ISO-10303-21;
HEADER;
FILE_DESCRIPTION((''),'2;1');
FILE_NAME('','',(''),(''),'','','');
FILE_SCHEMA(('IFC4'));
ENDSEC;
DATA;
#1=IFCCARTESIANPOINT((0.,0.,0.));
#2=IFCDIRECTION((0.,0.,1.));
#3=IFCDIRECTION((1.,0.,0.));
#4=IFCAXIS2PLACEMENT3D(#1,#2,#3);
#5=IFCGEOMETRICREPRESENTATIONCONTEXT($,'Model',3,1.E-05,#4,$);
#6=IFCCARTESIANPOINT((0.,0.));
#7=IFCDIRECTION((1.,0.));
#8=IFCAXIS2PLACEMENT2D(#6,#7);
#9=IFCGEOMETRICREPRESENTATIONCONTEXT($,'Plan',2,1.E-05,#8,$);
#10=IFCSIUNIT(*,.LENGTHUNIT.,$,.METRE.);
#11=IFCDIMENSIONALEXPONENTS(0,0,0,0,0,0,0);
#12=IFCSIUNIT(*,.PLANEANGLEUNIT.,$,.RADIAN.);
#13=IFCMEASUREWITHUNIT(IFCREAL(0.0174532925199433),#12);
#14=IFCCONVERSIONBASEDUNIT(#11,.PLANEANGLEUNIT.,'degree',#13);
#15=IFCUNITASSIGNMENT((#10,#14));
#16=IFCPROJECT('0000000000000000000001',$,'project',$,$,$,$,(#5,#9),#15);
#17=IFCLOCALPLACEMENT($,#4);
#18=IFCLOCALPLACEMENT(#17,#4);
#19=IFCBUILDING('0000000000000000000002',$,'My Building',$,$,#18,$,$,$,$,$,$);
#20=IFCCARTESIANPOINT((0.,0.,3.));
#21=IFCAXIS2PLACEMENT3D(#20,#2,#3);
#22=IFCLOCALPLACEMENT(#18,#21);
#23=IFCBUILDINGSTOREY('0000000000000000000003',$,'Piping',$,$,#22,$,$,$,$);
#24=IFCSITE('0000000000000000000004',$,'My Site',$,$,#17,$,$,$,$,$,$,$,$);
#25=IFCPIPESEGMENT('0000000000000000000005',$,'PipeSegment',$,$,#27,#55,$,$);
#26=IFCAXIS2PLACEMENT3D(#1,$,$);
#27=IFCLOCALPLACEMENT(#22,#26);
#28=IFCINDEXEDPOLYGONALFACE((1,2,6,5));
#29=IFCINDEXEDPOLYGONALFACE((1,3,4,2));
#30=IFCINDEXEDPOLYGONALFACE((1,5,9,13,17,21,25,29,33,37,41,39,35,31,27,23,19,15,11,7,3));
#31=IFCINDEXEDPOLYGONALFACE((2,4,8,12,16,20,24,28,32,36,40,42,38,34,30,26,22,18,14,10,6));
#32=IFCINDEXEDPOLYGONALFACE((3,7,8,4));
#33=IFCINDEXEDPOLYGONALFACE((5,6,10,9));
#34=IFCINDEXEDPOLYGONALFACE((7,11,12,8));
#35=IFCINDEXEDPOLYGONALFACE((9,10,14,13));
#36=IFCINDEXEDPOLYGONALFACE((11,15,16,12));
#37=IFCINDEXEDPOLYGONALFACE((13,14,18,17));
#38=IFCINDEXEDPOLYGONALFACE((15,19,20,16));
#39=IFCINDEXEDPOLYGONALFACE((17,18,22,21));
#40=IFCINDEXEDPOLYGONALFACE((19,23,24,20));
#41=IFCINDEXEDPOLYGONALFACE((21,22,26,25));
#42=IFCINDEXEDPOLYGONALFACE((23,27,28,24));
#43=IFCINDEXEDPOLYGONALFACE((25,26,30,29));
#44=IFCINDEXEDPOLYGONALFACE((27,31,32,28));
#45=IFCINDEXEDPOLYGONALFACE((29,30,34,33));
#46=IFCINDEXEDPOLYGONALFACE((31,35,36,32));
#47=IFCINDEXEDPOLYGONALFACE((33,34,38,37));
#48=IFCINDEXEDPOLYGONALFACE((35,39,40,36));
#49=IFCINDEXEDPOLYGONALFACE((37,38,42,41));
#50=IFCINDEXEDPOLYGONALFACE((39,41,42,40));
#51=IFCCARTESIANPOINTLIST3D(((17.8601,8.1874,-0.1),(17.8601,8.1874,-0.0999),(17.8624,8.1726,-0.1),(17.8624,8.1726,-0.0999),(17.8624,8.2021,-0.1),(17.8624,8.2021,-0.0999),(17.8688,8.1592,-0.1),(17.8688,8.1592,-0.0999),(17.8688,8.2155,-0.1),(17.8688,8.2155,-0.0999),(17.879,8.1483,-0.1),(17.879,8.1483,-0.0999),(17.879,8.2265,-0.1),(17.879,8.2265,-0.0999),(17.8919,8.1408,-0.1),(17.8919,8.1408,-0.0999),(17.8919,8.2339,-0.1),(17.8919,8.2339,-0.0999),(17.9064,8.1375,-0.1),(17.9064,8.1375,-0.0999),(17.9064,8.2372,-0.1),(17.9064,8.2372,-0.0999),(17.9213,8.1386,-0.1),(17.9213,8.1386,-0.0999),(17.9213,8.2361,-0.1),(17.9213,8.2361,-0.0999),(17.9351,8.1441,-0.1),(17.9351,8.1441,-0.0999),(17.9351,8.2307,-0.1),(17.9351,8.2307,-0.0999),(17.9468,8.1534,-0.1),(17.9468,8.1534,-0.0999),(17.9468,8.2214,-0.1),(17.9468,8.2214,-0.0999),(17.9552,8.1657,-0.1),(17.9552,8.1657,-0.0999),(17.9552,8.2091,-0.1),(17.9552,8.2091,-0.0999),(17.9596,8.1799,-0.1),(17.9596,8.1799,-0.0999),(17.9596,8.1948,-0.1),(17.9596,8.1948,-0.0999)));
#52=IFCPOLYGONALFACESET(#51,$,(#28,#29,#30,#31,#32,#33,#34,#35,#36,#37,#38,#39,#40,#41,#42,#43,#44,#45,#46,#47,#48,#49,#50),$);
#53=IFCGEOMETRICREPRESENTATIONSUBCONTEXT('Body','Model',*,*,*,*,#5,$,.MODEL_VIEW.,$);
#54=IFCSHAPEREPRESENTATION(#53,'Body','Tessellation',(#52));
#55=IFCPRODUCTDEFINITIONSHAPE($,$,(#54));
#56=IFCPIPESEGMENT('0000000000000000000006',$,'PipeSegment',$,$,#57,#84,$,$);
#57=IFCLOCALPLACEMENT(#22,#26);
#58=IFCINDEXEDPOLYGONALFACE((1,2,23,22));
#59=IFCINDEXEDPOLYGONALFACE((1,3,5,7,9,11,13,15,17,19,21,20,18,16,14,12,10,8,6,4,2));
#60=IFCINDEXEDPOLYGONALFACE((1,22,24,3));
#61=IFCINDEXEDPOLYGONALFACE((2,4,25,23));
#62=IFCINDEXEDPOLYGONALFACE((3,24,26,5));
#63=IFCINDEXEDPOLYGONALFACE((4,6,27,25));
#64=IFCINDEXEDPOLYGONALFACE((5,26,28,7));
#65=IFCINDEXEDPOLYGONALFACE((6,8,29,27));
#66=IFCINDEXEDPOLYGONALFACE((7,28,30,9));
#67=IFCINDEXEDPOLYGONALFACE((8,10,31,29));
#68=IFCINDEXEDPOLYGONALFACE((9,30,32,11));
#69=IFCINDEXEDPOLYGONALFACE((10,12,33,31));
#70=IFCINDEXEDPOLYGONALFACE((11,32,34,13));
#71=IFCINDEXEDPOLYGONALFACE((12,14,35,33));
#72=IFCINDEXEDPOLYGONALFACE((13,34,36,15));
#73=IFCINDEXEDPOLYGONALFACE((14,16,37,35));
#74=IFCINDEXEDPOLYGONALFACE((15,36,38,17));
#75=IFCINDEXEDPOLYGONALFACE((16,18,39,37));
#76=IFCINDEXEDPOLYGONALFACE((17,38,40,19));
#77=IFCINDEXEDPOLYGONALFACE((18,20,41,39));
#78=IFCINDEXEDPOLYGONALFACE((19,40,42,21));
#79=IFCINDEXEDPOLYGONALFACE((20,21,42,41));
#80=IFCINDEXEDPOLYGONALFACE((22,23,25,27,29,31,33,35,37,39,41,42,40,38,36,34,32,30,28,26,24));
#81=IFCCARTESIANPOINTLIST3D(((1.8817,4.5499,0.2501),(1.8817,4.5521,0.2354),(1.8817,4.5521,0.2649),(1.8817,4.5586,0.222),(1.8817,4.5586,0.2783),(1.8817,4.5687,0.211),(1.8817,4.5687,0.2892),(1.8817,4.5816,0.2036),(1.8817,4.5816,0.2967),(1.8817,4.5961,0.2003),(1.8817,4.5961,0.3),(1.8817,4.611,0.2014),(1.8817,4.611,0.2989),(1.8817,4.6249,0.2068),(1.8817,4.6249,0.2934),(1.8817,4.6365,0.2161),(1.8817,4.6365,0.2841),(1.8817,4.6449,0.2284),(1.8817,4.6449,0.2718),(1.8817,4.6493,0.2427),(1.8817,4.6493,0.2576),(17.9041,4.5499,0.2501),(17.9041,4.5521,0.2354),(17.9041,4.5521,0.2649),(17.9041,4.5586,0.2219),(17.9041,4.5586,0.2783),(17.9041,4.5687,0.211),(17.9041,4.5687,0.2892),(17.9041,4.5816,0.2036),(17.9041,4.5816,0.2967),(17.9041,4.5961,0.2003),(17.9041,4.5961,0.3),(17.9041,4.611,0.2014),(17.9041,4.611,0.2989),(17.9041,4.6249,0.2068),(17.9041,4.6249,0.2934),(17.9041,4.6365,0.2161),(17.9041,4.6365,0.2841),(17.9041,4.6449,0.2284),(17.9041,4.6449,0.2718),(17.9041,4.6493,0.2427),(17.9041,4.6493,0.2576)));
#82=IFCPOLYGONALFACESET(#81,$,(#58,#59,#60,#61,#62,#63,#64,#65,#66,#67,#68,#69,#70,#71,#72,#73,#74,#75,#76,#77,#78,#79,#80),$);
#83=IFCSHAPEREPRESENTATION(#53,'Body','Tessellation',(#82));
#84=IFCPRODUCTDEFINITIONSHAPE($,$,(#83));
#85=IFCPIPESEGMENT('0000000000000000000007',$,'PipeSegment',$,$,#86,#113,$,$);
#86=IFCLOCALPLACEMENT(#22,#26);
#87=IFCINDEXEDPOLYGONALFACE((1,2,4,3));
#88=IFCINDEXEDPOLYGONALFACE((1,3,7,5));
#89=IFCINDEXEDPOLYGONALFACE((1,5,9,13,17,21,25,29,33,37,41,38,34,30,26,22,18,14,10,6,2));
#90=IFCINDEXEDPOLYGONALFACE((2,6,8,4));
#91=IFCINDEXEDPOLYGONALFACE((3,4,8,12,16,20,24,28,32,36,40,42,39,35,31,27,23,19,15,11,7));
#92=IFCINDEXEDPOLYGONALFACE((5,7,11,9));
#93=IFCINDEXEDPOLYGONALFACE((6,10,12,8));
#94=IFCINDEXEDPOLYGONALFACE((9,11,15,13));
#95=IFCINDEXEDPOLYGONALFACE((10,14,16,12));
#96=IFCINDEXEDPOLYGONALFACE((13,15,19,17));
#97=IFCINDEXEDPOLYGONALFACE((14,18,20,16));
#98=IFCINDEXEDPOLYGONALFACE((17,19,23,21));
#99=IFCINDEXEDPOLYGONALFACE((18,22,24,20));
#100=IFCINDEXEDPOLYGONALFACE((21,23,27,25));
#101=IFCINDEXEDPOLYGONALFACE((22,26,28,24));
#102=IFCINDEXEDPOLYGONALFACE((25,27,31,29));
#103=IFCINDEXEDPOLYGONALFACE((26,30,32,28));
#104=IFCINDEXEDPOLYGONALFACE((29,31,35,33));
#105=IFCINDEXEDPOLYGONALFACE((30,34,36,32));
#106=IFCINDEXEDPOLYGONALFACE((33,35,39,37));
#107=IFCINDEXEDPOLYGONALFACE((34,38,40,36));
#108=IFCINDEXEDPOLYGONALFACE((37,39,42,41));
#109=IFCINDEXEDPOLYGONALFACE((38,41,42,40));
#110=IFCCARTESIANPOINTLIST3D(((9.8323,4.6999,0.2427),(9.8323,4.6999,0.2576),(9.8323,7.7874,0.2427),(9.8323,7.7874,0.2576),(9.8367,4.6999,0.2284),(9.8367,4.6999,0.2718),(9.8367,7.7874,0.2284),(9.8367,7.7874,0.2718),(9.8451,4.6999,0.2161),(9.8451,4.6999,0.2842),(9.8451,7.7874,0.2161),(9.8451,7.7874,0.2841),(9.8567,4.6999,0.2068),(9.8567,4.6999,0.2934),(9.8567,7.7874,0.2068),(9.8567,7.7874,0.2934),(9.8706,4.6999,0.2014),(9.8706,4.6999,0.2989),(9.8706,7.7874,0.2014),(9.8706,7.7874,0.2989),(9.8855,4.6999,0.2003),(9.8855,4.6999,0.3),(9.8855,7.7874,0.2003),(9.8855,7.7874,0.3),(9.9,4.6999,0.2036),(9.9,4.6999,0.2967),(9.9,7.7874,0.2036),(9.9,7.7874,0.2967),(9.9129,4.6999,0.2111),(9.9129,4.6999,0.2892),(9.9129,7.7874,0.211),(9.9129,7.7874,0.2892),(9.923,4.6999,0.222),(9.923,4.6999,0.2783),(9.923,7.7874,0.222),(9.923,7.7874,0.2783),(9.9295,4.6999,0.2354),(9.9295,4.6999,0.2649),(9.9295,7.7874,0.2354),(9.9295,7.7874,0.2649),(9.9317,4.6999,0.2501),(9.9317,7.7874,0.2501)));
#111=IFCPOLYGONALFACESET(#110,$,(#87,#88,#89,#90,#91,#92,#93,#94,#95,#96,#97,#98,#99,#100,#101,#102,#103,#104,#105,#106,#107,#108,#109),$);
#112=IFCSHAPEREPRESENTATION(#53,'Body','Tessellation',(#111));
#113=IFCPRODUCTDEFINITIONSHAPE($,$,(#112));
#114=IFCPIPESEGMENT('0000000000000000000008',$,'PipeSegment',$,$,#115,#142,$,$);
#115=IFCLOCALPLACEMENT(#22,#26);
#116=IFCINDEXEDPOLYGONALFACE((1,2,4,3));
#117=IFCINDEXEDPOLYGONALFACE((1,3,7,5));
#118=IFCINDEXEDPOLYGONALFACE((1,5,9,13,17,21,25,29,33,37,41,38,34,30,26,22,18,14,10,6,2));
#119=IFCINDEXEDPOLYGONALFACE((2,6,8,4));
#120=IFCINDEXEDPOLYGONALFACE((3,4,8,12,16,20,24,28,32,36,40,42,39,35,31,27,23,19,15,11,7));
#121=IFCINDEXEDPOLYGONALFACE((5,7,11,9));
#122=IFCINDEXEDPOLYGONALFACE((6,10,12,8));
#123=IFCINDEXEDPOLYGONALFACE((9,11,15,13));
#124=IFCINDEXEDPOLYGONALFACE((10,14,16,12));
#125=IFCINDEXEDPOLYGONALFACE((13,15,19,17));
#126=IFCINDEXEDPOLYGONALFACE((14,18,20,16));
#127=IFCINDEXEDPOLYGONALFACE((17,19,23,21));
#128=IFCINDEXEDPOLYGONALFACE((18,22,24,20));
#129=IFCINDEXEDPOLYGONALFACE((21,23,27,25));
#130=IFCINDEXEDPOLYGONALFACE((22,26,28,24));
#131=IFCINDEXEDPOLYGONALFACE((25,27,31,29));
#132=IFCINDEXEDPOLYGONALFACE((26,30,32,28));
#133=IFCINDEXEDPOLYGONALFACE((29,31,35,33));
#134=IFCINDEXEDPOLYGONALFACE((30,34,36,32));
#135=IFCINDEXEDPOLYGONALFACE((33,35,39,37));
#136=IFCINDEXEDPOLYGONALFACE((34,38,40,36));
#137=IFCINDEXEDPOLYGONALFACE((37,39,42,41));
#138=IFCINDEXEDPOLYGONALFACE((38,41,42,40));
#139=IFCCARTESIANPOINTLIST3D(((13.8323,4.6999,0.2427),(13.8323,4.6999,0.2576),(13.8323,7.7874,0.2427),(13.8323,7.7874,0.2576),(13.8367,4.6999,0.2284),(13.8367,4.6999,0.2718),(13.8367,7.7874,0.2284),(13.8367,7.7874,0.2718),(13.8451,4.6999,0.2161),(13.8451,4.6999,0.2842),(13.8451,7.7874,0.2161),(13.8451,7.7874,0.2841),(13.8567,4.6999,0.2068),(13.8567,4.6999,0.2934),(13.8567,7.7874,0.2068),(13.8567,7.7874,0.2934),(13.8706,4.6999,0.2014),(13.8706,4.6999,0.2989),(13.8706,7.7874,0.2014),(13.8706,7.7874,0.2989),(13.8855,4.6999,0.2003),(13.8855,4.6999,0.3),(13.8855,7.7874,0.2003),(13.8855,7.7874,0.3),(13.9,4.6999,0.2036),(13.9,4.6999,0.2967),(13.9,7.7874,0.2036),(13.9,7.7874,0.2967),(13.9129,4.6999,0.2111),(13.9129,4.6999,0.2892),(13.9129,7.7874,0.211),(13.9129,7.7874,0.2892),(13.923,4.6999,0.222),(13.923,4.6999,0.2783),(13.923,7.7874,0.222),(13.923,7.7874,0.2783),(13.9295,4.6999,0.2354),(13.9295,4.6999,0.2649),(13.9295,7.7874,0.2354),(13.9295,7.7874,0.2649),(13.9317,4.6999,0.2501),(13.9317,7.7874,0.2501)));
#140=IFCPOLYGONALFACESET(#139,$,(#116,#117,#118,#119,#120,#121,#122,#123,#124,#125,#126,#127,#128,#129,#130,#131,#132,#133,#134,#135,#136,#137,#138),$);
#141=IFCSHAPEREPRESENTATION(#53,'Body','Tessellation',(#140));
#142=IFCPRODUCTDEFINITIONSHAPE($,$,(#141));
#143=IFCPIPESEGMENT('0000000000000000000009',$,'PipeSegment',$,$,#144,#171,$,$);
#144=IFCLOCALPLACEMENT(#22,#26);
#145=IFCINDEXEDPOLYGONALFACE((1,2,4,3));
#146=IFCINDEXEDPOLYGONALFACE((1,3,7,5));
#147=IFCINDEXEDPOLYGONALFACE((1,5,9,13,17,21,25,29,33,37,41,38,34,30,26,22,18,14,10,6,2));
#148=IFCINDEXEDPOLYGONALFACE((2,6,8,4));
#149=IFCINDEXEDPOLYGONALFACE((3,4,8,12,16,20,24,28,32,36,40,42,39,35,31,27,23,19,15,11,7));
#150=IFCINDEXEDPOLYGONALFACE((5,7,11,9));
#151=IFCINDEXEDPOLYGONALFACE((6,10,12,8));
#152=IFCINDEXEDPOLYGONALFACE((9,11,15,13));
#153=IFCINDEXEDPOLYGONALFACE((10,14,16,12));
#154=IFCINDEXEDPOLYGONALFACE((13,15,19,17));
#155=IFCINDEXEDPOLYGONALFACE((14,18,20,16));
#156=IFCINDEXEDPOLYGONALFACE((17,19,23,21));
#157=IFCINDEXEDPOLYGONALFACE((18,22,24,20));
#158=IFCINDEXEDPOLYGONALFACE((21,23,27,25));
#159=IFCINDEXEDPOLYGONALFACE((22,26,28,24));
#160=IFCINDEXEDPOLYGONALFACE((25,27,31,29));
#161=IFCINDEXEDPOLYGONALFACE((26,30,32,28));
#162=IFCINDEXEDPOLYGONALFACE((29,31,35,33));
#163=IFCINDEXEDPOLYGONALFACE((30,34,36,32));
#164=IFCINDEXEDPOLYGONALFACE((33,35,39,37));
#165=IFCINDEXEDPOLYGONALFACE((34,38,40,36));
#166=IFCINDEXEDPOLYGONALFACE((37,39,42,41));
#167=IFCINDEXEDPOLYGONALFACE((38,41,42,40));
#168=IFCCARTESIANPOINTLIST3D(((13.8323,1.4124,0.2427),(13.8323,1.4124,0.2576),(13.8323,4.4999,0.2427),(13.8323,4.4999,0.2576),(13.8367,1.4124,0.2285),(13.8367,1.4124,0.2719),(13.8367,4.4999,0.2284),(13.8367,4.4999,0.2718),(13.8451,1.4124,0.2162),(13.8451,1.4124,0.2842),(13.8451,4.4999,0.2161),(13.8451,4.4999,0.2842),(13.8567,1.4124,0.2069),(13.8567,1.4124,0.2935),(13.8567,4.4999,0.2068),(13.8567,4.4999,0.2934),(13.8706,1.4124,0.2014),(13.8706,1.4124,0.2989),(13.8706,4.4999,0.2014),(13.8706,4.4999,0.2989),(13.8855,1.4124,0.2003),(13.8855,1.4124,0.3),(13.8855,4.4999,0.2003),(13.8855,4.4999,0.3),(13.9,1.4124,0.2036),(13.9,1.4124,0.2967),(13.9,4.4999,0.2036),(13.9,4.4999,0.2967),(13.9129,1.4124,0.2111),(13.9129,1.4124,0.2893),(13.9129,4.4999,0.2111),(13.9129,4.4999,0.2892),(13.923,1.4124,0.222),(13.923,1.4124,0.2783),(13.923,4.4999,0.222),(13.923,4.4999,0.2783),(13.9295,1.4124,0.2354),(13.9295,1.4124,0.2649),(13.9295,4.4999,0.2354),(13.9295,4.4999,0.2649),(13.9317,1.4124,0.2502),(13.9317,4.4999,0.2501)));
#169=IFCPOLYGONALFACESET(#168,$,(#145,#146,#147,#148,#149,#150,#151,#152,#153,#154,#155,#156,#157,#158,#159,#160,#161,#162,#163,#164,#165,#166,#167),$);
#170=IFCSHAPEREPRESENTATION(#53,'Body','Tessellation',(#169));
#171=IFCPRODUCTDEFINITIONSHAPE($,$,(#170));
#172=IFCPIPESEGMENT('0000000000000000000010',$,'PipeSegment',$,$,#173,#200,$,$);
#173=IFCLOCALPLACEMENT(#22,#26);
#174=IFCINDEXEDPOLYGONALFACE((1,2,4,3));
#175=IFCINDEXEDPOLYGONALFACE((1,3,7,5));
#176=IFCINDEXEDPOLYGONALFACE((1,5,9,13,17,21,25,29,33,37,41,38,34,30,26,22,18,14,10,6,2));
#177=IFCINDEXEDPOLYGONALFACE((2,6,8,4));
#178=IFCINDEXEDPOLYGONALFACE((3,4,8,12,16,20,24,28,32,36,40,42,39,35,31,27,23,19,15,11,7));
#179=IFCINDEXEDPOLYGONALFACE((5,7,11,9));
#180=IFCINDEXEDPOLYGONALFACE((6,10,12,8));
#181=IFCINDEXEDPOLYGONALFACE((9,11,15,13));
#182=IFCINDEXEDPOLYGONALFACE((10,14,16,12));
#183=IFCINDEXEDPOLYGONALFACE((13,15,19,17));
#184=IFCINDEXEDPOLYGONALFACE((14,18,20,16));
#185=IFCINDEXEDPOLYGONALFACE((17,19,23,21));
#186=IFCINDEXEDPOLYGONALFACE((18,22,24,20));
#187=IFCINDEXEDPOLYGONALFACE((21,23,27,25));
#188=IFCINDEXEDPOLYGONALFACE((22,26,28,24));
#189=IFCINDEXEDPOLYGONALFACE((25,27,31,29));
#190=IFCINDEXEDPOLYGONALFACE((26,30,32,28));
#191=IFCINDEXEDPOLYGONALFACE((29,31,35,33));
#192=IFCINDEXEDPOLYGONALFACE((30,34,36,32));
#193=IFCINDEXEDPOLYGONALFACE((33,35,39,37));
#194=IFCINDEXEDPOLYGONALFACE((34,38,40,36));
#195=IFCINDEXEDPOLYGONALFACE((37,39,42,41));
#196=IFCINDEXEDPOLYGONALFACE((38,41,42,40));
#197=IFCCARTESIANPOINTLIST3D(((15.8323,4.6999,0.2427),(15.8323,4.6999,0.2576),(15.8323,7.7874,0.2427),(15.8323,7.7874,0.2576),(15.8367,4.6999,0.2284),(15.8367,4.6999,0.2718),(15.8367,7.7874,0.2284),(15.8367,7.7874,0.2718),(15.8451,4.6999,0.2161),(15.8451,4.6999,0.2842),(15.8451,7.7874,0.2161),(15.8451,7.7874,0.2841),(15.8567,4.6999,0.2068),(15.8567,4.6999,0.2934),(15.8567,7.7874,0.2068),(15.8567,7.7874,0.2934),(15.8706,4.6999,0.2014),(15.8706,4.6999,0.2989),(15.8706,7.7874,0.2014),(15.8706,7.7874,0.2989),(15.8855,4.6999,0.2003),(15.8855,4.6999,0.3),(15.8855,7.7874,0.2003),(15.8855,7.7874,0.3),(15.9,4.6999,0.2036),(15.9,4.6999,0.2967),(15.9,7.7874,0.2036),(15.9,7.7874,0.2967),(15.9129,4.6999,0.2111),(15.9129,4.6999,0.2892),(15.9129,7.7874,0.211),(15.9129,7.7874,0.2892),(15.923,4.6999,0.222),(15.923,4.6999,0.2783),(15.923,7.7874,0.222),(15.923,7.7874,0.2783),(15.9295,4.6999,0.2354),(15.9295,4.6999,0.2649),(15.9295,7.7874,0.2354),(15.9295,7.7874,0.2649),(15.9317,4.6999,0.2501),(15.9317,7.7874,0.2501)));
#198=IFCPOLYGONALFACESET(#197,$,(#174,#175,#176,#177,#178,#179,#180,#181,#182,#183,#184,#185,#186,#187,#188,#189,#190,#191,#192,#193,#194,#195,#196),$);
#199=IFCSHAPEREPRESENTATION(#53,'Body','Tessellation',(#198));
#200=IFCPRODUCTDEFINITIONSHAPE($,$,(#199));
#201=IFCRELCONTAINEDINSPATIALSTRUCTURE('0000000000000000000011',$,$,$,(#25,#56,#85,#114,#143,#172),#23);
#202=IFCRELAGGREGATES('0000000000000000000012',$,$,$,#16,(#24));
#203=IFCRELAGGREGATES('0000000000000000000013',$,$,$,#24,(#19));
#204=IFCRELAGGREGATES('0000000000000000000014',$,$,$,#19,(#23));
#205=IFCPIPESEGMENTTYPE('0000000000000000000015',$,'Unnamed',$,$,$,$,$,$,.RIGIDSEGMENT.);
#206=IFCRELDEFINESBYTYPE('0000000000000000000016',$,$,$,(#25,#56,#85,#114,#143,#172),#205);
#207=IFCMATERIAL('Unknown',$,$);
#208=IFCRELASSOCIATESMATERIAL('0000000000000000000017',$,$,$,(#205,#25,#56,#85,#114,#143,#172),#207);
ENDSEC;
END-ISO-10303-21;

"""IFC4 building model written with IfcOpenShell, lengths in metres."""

from ifc_helpers import new_model, entity, si_unit, converted_unit, frame, origin_with_axes, origin_2d_with_axis, place, context, subcontext, project, spatial, circle, extrude, material, material_profile, profile_set, profile_usage, type_object, element, save


model = new_model("IFC4")

# Units and contexts
model_context = context("Model", 3, precision=1e-05, world=origin_with_axes())
plan_context = context("Plan", 2, precision=1e-05, world=origin_2d_with_axis())
body_context = subcontext(model_context, "Body", "Model", "MODEL_VIEW")
ifc_project = project(units=[si_unit("LENGTHUNIT", "METRE"), converted_unit("PLANEANGLEUNIT", "degree", entity("IfcReal", 0.0174532925199433), si_unit("PLANEANGLEUNIT", "RADIAN"), dimensions=[0, 0, 0, 0, 0, 0, 0])], contexts=[model_context, plan_context])

# Site, building, storey
site_placement = place(None, origin_with_axes())
site = spatial("IfcSite", under=ifc_project, at=site_placement, Name="My Site")
building_placement = place(site_placement, origin_with_axes())
building = spatial("IfcBuilding", under=site, at=building_placement, Name="My Building")
storey_placement = place(building_placement, frame((0.0, 0.0, 3.0), z_axis=(0.0, 0.0, 1.0), x_axis=(1.0, 0.0, 0.0)))
storey = spatial("IfcBuildingStorey", under=building, at=storey_placement, Name="Piping")

# Pipe segments
ifc_material = material(Name="Unknown")
ifc_material_profile_1 = material_profile(ifc_material, circle(Radius=0.05))
ifc_profile_set_1 = profile_set([ifc_material_profile_1])
ifc_profile_usage_1 = profile_usage(ifc_profile_set_1, cardinal=5)
pipe_segment_type = type_object("IfcPipeSegmentType", Name="Unnamed", PredefinedType="RIGIDSEGMENT", material=ifc_profile_set_1)
pipe_segment_1_placement = place(storey_placement, frame((17.9101, 8.1874, -0.0999), z_axis=(0.0, 0.000015, -1.0), x_axis=(-1.0, 0.0, 0.0)))
element("IfcPipeSegment", 1, at=pipe_segment_1_placement, inside=storey, type_object=pipe_segment_type, material=ifc_profile_usage_1, Name="PipeSegment", context=body_context, shape_type="SweptSolid", body=[
    extrude(circle(Radius=0.05), origin_with_axes(), (0.0, 0.0, 1.0), 0.0002),
])
ifc_profile_usage_2 = profile_usage(ifc_profile_set_1, cardinal=5)
pipe_segment_2_placement = place(storey_placement, frame((17.9041, 4.5999, 0.2501), z_axis=(-1.0, 0.0, 0.0), x_axis=(0.0, -1.0, 0.0)))
element("IfcPipeSegment", 2, at=pipe_segment_2_placement, inside=storey, type_object=pipe_segment_type, material=ifc_profile_usage_2, Name="PipeSegment", context=body_context, shape_type="SweptSolid", body=[
    extrude(circle(Radius=0.05), origin_with_axes(), (0.0, 0.0, 1.0), 16.0224),
])
ifc_profile_usage_3 = profile_usage(ifc_profile_set_1, cardinal=5)
pipe_segment_3_placement = place(storey_placement, frame((9.8817, 4.6999, 0.2501), z_axis=(0.0, 1.0, -0.000008), x_axis=(1.0, 0.0, 0.0)))
element("IfcPipeSegment", 3, at=pipe_segment_3_placement, inside=storey, type_object=pipe_segment_type, material=ifc_profile_usage_3, Name="PipeSegment", context=body_context, shape_type="SweptSolid", body=[
    extrude(circle(Radius=0.05), origin_with_axes(), (0.0, 0.0, 1.0), 3.0875),
])
ifc_profile_usage_4 = profile_usage(ifc_profile_set_1, cardinal=5)
pipe_segment_4_placement = place(storey_placement, frame((13.8817, 4.6999, 0.2501), z_axis=(0.0, 1.0, -0.000008), x_axis=(1.0, 0.0, 0.0)))
element("IfcPipeSegment", 4, at=pipe_segment_4_placement, inside=storey, type_object=pipe_segment_type, material=ifc_profile_usage_4, Name="PipeSegment", context=body_context, shape_type="SweptSolid", body=[
    extrude(circle(Radius=0.05), origin_with_axes(), (0.0, 0.0, 1.0), 3.0875),
])
ifc_profile_usage_5 = profile_usage(ifc_profile_set_1, cardinal=5)
pipe_segment_5_placement = place(storey_placement, frame((13.8817, 4.4999, 0.2501), z_axis=(0.0, -1.0, 0.000008), x_axis=(1.0, 0.0, 0.0)))
element("IfcPipeSegment", 5, at=pipe_segment_5_placement, inside=storey, type_object=pipe_segment_type, material=ifc_profile_usage_5, Name="PipeSegment", context=body_context, shape_type="SweptSolid", body=[
    extrude(circle(Radius=0.05), origin_with_axes(), (0.0, 0.0, 1.0), 3.0875),
])
ifc_profile_usage_6 = profile_usage(ifc_profile_set_1, cardinal=5)
pipe_segment_6_placement = place(storey_placement, frame((15.8817, 4.6999, 0.2501), z_axis=(0.0, 1.0, -0.000008), x_axis=(1.0, 0.0, 0.0)))
element("IfcPipeSegment", 6, at=pipe_segment_6_placement, inside=storey, type_object=pipe_segment_type, material=ifc_profile_usage_6, Name="PipeSegment", context=body_context, shape_type="SweptSolid", body=[
    extrude(circle(Radius=0.05), origin_with_axes(), (0.0, 0.0, 1.0), 3.0875),
])

save(model, "model.ifc")
